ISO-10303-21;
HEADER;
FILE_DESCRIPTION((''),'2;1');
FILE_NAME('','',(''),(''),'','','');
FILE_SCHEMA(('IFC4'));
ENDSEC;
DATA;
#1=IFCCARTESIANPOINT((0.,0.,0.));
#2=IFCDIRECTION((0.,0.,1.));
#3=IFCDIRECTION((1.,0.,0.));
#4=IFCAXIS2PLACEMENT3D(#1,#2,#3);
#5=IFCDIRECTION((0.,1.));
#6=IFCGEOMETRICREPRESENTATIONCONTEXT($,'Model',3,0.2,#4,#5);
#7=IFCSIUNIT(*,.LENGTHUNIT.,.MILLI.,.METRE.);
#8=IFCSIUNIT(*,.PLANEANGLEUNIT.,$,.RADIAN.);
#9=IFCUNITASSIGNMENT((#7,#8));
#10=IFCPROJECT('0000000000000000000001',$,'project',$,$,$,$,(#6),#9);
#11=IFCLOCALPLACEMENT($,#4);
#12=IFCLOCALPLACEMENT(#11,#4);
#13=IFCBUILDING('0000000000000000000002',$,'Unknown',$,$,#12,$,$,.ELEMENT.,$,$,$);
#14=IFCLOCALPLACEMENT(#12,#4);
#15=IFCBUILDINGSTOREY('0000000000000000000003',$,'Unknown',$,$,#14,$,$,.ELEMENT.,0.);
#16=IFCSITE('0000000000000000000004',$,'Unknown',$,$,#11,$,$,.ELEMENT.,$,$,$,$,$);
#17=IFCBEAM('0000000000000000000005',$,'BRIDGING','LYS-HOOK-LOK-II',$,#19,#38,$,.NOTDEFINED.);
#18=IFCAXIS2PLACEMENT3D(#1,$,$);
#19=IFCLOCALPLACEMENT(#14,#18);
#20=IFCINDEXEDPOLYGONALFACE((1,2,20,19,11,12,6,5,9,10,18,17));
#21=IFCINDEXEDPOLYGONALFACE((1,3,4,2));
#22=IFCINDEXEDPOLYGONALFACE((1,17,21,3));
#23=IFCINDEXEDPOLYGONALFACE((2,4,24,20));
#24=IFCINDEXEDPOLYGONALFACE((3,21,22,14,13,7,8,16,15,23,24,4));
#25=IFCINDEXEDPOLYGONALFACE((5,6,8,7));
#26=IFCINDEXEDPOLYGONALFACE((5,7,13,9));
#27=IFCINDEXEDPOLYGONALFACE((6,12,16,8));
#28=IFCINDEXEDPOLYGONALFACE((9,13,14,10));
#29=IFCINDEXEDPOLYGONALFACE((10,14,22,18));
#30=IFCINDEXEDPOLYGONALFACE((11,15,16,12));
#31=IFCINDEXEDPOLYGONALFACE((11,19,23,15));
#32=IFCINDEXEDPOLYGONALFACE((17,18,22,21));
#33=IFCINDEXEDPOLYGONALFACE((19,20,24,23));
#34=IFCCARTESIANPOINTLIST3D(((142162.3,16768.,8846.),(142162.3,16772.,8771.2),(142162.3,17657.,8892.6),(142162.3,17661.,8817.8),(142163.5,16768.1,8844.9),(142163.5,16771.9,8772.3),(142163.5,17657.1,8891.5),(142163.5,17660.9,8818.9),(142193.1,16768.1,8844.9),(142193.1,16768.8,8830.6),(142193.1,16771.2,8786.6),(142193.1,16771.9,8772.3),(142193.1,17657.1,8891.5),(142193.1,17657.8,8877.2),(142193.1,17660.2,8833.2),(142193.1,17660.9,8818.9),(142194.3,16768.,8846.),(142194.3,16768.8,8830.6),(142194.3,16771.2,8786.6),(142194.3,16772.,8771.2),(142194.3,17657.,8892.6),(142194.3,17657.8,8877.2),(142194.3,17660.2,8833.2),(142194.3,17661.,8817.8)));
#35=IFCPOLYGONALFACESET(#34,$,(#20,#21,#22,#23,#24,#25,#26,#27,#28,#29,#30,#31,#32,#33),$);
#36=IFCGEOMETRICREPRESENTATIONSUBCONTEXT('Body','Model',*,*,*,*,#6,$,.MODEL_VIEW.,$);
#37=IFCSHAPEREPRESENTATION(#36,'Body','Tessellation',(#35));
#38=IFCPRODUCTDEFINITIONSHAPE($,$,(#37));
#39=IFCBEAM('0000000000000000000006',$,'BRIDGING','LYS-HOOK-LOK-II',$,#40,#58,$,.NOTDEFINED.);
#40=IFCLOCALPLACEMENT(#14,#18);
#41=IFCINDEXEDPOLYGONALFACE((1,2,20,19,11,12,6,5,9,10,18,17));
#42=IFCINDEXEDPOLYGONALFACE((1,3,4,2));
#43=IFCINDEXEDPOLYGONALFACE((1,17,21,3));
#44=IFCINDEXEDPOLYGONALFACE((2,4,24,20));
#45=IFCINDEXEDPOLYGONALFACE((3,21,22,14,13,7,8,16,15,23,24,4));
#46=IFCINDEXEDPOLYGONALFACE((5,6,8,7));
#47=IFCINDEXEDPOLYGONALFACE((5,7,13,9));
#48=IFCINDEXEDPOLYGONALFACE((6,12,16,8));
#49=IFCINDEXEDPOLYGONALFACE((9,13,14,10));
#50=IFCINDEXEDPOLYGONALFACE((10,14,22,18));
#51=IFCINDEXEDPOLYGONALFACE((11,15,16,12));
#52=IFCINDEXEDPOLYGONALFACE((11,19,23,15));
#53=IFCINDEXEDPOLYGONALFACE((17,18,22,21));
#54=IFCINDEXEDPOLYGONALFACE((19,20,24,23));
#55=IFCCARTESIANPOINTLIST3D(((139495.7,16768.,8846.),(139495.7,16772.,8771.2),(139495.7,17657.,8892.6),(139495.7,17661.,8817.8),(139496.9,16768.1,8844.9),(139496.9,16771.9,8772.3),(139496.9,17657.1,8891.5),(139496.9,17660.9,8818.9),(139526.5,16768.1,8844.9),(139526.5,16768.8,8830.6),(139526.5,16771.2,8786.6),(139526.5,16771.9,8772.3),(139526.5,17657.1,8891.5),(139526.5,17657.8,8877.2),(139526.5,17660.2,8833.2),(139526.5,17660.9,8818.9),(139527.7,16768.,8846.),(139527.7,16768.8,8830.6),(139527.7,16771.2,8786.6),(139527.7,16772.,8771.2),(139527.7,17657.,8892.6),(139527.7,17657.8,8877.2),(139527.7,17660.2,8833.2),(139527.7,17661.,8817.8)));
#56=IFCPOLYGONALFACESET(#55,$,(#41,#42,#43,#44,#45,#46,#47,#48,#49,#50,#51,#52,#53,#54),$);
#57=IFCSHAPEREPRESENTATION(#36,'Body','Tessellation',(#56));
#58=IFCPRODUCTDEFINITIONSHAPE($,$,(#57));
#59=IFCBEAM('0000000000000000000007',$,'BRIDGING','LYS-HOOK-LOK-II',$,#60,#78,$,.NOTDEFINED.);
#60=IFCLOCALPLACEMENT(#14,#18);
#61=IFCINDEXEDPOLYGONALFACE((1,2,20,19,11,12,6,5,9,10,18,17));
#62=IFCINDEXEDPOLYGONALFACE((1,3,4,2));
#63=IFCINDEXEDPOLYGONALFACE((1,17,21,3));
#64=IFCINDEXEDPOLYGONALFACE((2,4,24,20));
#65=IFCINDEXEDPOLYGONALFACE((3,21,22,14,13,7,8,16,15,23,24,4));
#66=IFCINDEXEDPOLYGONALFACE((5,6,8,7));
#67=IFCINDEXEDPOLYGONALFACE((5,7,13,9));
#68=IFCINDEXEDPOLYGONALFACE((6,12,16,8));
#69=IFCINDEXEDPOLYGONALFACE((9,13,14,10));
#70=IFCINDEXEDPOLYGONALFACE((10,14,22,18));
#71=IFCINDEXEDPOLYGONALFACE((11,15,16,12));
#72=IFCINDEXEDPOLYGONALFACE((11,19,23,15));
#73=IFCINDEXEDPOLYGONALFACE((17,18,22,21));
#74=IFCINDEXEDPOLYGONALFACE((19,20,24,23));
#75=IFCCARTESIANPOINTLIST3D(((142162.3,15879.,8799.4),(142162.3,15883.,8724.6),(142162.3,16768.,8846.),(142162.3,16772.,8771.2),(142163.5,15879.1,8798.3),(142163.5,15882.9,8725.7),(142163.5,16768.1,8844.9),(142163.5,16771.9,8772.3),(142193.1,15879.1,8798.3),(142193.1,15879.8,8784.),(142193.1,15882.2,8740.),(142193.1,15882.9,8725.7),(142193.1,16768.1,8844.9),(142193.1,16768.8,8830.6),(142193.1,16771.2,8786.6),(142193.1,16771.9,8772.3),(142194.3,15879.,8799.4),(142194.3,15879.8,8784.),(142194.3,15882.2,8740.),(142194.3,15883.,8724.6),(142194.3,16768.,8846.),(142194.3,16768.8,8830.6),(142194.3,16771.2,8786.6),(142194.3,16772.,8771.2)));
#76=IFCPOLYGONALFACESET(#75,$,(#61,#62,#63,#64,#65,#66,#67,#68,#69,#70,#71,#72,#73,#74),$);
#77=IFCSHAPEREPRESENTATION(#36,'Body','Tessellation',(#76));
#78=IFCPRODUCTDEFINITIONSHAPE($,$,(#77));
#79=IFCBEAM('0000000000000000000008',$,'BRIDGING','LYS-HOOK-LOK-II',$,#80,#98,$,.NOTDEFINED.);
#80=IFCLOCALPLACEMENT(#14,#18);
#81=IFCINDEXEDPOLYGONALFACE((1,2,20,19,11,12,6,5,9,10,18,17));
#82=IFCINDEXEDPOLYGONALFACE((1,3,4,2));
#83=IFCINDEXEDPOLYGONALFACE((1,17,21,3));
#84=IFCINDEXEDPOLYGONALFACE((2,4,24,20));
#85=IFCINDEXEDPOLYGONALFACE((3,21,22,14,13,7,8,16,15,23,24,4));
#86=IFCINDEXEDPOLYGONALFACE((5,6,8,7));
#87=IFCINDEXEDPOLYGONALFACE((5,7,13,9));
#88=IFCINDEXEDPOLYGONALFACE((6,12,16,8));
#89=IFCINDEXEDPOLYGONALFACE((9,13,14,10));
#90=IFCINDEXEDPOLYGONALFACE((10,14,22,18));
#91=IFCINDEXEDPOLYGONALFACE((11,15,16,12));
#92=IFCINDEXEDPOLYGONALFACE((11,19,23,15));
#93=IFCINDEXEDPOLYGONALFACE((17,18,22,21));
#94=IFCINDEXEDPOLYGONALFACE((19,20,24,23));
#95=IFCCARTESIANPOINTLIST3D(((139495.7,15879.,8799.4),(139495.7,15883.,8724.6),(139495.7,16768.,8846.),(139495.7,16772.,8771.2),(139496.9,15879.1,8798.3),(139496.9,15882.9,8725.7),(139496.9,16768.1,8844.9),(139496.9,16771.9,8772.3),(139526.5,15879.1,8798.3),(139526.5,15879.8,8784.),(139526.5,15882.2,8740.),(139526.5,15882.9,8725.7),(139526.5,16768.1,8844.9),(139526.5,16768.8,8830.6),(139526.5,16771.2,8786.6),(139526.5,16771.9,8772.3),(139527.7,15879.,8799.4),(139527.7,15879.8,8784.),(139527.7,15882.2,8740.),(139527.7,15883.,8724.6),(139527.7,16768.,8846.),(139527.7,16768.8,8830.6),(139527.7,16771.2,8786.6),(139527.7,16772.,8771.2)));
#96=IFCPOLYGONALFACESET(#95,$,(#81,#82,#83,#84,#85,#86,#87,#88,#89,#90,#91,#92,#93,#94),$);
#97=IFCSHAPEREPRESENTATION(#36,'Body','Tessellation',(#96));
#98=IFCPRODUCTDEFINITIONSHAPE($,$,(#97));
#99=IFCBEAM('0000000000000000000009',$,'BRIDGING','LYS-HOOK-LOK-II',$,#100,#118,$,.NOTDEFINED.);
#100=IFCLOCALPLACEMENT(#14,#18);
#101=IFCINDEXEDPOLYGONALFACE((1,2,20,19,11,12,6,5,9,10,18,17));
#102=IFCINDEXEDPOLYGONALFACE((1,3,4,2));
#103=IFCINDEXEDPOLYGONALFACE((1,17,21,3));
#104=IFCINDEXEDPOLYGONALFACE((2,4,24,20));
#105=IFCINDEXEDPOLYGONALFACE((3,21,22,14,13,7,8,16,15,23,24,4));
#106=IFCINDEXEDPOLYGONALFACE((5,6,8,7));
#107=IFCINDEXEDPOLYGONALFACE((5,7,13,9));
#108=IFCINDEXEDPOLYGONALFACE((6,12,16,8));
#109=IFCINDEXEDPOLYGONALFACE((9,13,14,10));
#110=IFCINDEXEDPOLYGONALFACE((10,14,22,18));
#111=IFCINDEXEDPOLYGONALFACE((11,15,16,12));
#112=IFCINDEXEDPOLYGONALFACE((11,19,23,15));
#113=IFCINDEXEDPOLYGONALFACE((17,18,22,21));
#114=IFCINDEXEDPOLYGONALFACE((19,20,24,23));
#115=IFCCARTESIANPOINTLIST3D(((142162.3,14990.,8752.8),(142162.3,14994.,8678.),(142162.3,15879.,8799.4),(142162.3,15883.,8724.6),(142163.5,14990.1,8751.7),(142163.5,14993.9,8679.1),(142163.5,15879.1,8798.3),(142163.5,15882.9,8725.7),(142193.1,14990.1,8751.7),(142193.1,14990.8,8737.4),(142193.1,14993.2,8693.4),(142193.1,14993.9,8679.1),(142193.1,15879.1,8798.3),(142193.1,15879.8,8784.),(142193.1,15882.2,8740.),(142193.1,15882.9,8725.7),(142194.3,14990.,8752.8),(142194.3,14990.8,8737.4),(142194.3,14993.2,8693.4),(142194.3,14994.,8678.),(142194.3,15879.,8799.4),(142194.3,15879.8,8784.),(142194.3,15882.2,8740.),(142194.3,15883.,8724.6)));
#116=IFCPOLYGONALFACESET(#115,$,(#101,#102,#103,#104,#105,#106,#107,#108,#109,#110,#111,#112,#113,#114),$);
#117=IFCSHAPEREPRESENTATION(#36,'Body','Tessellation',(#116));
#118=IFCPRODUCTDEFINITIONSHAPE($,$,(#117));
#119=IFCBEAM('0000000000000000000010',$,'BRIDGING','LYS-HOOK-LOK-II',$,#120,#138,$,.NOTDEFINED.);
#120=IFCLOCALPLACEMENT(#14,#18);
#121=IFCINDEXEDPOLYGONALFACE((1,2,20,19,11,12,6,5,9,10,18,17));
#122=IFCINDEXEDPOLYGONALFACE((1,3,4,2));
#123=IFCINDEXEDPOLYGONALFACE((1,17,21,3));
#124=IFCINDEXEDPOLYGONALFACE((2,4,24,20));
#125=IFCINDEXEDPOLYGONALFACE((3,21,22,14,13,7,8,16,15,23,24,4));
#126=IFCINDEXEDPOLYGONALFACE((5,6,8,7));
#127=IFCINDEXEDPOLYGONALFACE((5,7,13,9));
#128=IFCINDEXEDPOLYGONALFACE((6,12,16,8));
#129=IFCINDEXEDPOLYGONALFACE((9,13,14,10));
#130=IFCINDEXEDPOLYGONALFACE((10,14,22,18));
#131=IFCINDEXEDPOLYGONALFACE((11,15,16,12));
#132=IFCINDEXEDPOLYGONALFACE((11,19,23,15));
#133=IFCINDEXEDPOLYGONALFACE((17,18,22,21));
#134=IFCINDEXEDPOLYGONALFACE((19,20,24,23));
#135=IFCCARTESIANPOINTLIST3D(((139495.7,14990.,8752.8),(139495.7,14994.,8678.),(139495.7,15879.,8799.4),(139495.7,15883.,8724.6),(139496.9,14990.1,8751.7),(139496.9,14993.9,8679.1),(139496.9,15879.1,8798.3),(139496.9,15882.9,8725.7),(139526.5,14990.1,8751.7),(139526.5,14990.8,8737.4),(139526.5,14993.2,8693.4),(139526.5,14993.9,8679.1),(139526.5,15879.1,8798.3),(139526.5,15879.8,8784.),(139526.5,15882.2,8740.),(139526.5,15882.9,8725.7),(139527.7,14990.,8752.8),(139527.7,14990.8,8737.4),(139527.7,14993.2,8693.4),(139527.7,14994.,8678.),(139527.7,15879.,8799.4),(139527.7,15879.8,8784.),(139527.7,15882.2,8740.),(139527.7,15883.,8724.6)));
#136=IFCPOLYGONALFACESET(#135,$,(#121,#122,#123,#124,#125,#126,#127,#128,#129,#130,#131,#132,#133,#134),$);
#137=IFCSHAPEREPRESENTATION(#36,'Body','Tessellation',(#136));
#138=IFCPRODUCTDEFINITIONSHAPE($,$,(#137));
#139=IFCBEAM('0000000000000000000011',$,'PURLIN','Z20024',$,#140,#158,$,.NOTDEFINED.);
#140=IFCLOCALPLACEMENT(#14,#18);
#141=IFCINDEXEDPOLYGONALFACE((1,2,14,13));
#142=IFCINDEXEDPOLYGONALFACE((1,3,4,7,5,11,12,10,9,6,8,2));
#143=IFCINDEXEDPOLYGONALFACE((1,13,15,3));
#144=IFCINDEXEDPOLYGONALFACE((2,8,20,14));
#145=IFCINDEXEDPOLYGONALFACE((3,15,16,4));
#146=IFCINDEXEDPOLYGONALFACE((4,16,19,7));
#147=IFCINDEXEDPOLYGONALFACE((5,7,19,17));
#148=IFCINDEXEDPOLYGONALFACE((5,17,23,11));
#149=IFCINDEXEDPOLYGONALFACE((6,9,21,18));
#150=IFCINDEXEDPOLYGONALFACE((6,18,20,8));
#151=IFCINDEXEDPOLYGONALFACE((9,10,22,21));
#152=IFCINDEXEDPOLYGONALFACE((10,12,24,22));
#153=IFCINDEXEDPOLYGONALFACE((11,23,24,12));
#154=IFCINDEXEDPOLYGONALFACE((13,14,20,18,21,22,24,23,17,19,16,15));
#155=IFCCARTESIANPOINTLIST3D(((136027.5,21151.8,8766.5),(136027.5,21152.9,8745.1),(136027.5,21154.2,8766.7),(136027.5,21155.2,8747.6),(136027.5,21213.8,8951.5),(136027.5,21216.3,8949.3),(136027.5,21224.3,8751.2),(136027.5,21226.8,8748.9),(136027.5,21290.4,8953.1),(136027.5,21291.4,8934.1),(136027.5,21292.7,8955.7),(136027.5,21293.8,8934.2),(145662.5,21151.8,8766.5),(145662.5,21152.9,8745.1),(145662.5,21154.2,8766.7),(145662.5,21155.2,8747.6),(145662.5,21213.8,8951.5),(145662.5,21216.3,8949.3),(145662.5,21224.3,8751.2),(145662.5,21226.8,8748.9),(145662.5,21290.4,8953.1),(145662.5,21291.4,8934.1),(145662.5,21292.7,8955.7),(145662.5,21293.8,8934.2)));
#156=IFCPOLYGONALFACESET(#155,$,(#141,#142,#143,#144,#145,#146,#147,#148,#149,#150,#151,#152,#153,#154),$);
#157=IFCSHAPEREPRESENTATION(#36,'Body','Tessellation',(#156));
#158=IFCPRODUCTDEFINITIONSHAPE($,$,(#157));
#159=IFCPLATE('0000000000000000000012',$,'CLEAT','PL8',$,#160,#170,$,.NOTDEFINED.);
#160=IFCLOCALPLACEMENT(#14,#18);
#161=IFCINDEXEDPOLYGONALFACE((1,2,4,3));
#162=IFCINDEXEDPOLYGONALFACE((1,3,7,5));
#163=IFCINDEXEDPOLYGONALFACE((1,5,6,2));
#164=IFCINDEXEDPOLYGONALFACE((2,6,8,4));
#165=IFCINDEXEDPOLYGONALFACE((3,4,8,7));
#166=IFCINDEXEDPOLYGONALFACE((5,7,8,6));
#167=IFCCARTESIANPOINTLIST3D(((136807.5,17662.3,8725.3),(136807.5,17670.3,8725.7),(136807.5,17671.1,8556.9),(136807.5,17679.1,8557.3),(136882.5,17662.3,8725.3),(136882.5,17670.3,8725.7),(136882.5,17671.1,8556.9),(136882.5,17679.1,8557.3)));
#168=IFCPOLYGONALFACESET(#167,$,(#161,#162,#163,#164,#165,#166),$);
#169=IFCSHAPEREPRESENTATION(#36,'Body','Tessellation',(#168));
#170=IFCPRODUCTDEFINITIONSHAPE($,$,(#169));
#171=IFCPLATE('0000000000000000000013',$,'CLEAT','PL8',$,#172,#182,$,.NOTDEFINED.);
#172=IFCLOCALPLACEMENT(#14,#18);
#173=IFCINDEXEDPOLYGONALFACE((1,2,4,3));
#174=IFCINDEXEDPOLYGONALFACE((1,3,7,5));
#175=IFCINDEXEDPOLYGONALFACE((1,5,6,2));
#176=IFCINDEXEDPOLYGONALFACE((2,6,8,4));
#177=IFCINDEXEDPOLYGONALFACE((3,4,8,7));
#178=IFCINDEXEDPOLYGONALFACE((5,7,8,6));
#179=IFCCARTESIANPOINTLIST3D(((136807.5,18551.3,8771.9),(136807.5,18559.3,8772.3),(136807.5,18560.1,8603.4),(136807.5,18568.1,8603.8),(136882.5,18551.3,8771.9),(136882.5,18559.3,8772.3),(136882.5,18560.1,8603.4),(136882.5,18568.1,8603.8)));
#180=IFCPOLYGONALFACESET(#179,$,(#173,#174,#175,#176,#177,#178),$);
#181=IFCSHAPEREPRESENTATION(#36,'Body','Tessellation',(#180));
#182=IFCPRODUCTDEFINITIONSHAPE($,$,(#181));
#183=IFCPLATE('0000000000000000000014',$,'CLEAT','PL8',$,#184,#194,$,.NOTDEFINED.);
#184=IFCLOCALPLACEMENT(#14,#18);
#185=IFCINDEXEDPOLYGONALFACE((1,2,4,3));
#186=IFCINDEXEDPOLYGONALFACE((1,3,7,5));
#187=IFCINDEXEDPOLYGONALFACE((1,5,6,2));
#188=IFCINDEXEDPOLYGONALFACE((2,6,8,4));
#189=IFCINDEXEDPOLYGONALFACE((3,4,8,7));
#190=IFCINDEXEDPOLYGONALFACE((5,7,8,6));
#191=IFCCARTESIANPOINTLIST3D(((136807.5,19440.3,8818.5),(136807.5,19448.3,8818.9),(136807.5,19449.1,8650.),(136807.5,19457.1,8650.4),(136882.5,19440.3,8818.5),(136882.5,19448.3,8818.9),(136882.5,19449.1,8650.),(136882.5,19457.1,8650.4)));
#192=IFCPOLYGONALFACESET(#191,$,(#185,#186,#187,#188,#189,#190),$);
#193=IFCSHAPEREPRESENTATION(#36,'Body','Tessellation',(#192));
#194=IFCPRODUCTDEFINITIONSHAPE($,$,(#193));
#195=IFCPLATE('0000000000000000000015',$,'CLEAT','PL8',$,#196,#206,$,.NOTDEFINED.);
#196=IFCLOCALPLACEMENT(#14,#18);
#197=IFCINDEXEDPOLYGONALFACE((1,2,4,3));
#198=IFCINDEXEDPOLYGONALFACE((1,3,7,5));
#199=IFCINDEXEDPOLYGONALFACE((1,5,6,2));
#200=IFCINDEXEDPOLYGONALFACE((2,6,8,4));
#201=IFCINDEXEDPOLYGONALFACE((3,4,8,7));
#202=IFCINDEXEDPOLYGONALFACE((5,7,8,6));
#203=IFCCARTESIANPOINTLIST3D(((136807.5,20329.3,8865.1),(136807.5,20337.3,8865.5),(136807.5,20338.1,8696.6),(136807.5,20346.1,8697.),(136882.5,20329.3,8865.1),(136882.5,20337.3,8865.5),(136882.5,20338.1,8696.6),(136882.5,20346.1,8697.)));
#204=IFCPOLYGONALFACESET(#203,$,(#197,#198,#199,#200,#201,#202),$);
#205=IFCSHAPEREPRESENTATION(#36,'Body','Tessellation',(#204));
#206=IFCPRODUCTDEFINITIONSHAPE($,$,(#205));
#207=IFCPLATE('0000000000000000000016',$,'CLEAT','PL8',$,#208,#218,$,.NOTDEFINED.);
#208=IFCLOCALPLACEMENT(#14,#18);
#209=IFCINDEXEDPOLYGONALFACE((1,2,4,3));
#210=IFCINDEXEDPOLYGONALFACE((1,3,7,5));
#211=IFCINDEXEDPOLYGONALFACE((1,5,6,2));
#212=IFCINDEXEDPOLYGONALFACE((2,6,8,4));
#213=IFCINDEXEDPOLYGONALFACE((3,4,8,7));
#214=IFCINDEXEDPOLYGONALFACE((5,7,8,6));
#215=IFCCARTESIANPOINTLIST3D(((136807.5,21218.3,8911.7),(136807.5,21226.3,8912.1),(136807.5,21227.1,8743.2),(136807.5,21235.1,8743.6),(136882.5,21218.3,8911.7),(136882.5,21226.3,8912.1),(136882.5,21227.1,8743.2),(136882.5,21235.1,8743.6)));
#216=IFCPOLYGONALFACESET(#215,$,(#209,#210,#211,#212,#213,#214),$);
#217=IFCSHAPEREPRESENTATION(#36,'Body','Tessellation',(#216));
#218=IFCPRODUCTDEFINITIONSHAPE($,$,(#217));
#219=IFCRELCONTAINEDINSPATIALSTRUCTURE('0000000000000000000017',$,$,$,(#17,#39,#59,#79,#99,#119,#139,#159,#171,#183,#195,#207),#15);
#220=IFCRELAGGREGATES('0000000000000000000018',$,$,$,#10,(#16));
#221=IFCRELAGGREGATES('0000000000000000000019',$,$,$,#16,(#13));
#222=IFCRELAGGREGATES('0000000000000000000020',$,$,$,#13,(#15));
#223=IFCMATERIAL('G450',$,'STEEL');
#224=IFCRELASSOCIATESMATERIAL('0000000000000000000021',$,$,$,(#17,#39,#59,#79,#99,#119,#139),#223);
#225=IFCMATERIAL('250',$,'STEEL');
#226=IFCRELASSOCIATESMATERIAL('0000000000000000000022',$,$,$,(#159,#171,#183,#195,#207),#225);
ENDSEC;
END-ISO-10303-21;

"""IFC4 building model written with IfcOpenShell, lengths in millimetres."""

from ifc_helpers import new_model, si_unit, direction, frame, origin_with_axes, place, context, subcontext, project, spatial, line, indexed_curve, outline, extrude, material, element, save


model = new_model("IFC4")

# Units and contexts
model_context = context("Model", 3, precision=0.2, world=origin_with_axes(), true_north=direction((0.0, 1.0)))
body_context = subcontext(model_context, "Body", "Model", "MODEL_VIEW")
ifc_project = project(units=[si_unit("LENGTHUNIT", "METRE", prefix="MILLI"), si_unit("PLANEANGLEUNIT", "RADIAN")], contexts=[model_context])

# Site, building, storey
site_placement = place(None, origin_with_axes())
site = spatial("IfcSite", under=ifc_project, at=site_placement, Name="Unknown", CompositionType="ELEMENT")
building_placement = place(site_placement, origin_with_axes())
building = spatial("IfcBuilding", under=site, at=building_placement, Name="Unknown", CompositionType="ELEMENT")
storey_placement = place(building_placement, origin_with_axes())
storey = spatial("IfcBuildingStorey", under=building, at=storey_placement, Name="Unknown", CompositionType="ELEMENT", Elevation=0.0)

# Beams
ifc_material_1 = material(Name="G450", Category="STEEL")
for number, where, z_axis, x_axis, name in (
    (1, (142178.3, 16770.0, 8808.6), (1.0, 0.0, 0.0), (0.0, 0.998629, 0.052347), "BRIDGING"),
    (2, (139511.7, 16770.0, 8808.6), (1.0, 0.0, 0.0), (0.0, 0.998629, 0.052347), "BRIDGING"),
    (3, (142178.3, 15881.0, 8762.0), (1.0, 0.0, 0.0), (0.0, 0.998629, 0.052347), "BRIDGING"),
    (4, (139511.7, 15881.0, 8762.0), (1.0, 0.0, 0.0), (0.0, 0.998629, 0.052347), "BRIDGING"),
    (5, (142178.3, 14992.0, 8715.4), (1.0, 0.0, 0.0), (0.0, 0.998629, 0.052347), "BRIDGING"),
    (6, (139511.7, 14992.0, 8715.4), (1.0, 0.0, 0.0), (0.0, 0.998629, 0.052347), "BRIDGING"),
):
    element("IfcBeam", number, at=place(storey_placement, frame(where, z_axis=z_axis, x_axis=x_axis)), inside=storey, material=ifc_material_1, Name=name, Description="LYS-HOOK-LOK-II", PredefinedType="NOTDEFINED", context=body_context, shape_type="SolidModel", body=[
        extrude(outline(indexed_curve([(16.0, -37.5), (16.0, -22.0), (14.8, -22.0), (14.8, -36.3), (-14.8, -36.3), (-14.8, 36.3), (14.8, 36.3), (14.8, 22.0), (16.0, 22.0), (16.0, 37.5), (-16.0, 37.5), (-16.0, -37.5)], segments=[line(1, 2, 3, 4, 5, 6, 7, 8, 9, 10, 11, 12, 1)])), frame((0.0, 0.0, 0.0), z_axis=(-1.0, 0.0, 0.0), x_axis=(0.0, 0.0, 1.0)), (0.0, 0.0, -1.0), 890.2),
    ])
beam_placement = place(storey_placement, frame((136027.5, 21220.3, 8850.2), z_axis=(0.0, -0.99863, -0.052336), x_axis=(1.0, 0.0, 0.0)))
element("IfcBeam", 7, at=beam_placement, inside=storey, material=ifc_material_1, Name="PURLIN", Description="Z20024", PredefinedType="NOTDEFINED", context=body_context, shape_type="SolidModel", body=[
    extrude(outline(indexed_curve([(72.8, -101.5), (72.8, -80.0), (70.4, -80.0), (70.4, -99.1), (1.2, -99.1), (1.2, 101.5), (-77.8, 101.5), (-77.8, 80.0), (-75.4, 80.0), (-75.4, 99.1), (-1.2, 99.1), (-1.2, -101.5)], segments=[line(1, 2, 3, 4, 5, 6, 7, 8, 9, 10, 11, 12, 1)])), frame((0.0, 0.0, 0.0), z_axis=(-1.0, 0.0, 0.0), x_axis=(0.0, 0.0, 1.0)), (0.0, 0.0, -1.0), 9635.0),
])

# Plates
ifc_material_2 = material(Name="250", Category="STEEL")
plate_placement = place(storey_placement, frame((136807.5, 17666.3, 8725.5), z_axis=(0.0, 0.998637, 0.052185), x_axis=(1.0, 0.0, 0.0)))
element("IfcPlate", 8, at=plate_placement, inside=storey, material=ifc_material_2, Name="CLEAT", Description="PL8", PredefinedType="NOTDEFINED", context=body_context, shape_type="SolidModel", body=[
    extrude(outline(indexed_curve([(0.0, 0.0), (75.0, 0.0), (75.0, 168.6), (0.0, 168.6)], segments=[line(1, 2, 3, 4, 1)])), frame((0.0, 0.0, 4.0), z_axis=(0.0, 0.0, 1.0), x_axis=(1.0, 0.0, 0.0)), (0.0, 0.0, -1.0), 8.0),
])
for number, where, z_axis, x_axis, name in (
    (9, (136807.5, 18555.3, 8772.1), (0.0, 0.998639, 0.052154), (1.0, 0.0, 0.0), "CLEAT"),
    (10, (136807.5, 19444.3, 8818.7), (0.0, 0.998639, 0.052154), (1.0, 0.0, 0.0), "CLEAT"),
    (11, (136807.5, 20333.3, 8865.3), (0.0, 0.998639, 0.052154), (1.0, 0.0, 0.0), "CLEAT"),
    (12, (136807.5, 21222.3, 8911.9), (0.0, 0.998639, 0.052154), (1.0, 0.0, 0.0), "CLEAT"),
):
    element("IfcPlate", number, at=place(storey_placement, frame(where, z_axis=z_axis, x_axis=x_axis)), inside=storey, material=ifc_material_2, Name=name, Description="PL8", PredefinedType="NOTDEFINED", context=body_context, shape_type="SolidModel", body=[
        extrude(outline(indexed_curve([(0.0, 0.0), (75.0, 0.0), (75.0, 168.7), (0.0, 168.7)], segments=[line(1, 2, 3, 4, 1)])), frame((0.0, 0.0, 4.0), z_axis=(0.0, 0.0, 1.0), x_axis=(1.0, 0.0, 0.0)), (0.0, 0.0, -1.0), 8.0),
    ])

save(model, "model.ifc")
